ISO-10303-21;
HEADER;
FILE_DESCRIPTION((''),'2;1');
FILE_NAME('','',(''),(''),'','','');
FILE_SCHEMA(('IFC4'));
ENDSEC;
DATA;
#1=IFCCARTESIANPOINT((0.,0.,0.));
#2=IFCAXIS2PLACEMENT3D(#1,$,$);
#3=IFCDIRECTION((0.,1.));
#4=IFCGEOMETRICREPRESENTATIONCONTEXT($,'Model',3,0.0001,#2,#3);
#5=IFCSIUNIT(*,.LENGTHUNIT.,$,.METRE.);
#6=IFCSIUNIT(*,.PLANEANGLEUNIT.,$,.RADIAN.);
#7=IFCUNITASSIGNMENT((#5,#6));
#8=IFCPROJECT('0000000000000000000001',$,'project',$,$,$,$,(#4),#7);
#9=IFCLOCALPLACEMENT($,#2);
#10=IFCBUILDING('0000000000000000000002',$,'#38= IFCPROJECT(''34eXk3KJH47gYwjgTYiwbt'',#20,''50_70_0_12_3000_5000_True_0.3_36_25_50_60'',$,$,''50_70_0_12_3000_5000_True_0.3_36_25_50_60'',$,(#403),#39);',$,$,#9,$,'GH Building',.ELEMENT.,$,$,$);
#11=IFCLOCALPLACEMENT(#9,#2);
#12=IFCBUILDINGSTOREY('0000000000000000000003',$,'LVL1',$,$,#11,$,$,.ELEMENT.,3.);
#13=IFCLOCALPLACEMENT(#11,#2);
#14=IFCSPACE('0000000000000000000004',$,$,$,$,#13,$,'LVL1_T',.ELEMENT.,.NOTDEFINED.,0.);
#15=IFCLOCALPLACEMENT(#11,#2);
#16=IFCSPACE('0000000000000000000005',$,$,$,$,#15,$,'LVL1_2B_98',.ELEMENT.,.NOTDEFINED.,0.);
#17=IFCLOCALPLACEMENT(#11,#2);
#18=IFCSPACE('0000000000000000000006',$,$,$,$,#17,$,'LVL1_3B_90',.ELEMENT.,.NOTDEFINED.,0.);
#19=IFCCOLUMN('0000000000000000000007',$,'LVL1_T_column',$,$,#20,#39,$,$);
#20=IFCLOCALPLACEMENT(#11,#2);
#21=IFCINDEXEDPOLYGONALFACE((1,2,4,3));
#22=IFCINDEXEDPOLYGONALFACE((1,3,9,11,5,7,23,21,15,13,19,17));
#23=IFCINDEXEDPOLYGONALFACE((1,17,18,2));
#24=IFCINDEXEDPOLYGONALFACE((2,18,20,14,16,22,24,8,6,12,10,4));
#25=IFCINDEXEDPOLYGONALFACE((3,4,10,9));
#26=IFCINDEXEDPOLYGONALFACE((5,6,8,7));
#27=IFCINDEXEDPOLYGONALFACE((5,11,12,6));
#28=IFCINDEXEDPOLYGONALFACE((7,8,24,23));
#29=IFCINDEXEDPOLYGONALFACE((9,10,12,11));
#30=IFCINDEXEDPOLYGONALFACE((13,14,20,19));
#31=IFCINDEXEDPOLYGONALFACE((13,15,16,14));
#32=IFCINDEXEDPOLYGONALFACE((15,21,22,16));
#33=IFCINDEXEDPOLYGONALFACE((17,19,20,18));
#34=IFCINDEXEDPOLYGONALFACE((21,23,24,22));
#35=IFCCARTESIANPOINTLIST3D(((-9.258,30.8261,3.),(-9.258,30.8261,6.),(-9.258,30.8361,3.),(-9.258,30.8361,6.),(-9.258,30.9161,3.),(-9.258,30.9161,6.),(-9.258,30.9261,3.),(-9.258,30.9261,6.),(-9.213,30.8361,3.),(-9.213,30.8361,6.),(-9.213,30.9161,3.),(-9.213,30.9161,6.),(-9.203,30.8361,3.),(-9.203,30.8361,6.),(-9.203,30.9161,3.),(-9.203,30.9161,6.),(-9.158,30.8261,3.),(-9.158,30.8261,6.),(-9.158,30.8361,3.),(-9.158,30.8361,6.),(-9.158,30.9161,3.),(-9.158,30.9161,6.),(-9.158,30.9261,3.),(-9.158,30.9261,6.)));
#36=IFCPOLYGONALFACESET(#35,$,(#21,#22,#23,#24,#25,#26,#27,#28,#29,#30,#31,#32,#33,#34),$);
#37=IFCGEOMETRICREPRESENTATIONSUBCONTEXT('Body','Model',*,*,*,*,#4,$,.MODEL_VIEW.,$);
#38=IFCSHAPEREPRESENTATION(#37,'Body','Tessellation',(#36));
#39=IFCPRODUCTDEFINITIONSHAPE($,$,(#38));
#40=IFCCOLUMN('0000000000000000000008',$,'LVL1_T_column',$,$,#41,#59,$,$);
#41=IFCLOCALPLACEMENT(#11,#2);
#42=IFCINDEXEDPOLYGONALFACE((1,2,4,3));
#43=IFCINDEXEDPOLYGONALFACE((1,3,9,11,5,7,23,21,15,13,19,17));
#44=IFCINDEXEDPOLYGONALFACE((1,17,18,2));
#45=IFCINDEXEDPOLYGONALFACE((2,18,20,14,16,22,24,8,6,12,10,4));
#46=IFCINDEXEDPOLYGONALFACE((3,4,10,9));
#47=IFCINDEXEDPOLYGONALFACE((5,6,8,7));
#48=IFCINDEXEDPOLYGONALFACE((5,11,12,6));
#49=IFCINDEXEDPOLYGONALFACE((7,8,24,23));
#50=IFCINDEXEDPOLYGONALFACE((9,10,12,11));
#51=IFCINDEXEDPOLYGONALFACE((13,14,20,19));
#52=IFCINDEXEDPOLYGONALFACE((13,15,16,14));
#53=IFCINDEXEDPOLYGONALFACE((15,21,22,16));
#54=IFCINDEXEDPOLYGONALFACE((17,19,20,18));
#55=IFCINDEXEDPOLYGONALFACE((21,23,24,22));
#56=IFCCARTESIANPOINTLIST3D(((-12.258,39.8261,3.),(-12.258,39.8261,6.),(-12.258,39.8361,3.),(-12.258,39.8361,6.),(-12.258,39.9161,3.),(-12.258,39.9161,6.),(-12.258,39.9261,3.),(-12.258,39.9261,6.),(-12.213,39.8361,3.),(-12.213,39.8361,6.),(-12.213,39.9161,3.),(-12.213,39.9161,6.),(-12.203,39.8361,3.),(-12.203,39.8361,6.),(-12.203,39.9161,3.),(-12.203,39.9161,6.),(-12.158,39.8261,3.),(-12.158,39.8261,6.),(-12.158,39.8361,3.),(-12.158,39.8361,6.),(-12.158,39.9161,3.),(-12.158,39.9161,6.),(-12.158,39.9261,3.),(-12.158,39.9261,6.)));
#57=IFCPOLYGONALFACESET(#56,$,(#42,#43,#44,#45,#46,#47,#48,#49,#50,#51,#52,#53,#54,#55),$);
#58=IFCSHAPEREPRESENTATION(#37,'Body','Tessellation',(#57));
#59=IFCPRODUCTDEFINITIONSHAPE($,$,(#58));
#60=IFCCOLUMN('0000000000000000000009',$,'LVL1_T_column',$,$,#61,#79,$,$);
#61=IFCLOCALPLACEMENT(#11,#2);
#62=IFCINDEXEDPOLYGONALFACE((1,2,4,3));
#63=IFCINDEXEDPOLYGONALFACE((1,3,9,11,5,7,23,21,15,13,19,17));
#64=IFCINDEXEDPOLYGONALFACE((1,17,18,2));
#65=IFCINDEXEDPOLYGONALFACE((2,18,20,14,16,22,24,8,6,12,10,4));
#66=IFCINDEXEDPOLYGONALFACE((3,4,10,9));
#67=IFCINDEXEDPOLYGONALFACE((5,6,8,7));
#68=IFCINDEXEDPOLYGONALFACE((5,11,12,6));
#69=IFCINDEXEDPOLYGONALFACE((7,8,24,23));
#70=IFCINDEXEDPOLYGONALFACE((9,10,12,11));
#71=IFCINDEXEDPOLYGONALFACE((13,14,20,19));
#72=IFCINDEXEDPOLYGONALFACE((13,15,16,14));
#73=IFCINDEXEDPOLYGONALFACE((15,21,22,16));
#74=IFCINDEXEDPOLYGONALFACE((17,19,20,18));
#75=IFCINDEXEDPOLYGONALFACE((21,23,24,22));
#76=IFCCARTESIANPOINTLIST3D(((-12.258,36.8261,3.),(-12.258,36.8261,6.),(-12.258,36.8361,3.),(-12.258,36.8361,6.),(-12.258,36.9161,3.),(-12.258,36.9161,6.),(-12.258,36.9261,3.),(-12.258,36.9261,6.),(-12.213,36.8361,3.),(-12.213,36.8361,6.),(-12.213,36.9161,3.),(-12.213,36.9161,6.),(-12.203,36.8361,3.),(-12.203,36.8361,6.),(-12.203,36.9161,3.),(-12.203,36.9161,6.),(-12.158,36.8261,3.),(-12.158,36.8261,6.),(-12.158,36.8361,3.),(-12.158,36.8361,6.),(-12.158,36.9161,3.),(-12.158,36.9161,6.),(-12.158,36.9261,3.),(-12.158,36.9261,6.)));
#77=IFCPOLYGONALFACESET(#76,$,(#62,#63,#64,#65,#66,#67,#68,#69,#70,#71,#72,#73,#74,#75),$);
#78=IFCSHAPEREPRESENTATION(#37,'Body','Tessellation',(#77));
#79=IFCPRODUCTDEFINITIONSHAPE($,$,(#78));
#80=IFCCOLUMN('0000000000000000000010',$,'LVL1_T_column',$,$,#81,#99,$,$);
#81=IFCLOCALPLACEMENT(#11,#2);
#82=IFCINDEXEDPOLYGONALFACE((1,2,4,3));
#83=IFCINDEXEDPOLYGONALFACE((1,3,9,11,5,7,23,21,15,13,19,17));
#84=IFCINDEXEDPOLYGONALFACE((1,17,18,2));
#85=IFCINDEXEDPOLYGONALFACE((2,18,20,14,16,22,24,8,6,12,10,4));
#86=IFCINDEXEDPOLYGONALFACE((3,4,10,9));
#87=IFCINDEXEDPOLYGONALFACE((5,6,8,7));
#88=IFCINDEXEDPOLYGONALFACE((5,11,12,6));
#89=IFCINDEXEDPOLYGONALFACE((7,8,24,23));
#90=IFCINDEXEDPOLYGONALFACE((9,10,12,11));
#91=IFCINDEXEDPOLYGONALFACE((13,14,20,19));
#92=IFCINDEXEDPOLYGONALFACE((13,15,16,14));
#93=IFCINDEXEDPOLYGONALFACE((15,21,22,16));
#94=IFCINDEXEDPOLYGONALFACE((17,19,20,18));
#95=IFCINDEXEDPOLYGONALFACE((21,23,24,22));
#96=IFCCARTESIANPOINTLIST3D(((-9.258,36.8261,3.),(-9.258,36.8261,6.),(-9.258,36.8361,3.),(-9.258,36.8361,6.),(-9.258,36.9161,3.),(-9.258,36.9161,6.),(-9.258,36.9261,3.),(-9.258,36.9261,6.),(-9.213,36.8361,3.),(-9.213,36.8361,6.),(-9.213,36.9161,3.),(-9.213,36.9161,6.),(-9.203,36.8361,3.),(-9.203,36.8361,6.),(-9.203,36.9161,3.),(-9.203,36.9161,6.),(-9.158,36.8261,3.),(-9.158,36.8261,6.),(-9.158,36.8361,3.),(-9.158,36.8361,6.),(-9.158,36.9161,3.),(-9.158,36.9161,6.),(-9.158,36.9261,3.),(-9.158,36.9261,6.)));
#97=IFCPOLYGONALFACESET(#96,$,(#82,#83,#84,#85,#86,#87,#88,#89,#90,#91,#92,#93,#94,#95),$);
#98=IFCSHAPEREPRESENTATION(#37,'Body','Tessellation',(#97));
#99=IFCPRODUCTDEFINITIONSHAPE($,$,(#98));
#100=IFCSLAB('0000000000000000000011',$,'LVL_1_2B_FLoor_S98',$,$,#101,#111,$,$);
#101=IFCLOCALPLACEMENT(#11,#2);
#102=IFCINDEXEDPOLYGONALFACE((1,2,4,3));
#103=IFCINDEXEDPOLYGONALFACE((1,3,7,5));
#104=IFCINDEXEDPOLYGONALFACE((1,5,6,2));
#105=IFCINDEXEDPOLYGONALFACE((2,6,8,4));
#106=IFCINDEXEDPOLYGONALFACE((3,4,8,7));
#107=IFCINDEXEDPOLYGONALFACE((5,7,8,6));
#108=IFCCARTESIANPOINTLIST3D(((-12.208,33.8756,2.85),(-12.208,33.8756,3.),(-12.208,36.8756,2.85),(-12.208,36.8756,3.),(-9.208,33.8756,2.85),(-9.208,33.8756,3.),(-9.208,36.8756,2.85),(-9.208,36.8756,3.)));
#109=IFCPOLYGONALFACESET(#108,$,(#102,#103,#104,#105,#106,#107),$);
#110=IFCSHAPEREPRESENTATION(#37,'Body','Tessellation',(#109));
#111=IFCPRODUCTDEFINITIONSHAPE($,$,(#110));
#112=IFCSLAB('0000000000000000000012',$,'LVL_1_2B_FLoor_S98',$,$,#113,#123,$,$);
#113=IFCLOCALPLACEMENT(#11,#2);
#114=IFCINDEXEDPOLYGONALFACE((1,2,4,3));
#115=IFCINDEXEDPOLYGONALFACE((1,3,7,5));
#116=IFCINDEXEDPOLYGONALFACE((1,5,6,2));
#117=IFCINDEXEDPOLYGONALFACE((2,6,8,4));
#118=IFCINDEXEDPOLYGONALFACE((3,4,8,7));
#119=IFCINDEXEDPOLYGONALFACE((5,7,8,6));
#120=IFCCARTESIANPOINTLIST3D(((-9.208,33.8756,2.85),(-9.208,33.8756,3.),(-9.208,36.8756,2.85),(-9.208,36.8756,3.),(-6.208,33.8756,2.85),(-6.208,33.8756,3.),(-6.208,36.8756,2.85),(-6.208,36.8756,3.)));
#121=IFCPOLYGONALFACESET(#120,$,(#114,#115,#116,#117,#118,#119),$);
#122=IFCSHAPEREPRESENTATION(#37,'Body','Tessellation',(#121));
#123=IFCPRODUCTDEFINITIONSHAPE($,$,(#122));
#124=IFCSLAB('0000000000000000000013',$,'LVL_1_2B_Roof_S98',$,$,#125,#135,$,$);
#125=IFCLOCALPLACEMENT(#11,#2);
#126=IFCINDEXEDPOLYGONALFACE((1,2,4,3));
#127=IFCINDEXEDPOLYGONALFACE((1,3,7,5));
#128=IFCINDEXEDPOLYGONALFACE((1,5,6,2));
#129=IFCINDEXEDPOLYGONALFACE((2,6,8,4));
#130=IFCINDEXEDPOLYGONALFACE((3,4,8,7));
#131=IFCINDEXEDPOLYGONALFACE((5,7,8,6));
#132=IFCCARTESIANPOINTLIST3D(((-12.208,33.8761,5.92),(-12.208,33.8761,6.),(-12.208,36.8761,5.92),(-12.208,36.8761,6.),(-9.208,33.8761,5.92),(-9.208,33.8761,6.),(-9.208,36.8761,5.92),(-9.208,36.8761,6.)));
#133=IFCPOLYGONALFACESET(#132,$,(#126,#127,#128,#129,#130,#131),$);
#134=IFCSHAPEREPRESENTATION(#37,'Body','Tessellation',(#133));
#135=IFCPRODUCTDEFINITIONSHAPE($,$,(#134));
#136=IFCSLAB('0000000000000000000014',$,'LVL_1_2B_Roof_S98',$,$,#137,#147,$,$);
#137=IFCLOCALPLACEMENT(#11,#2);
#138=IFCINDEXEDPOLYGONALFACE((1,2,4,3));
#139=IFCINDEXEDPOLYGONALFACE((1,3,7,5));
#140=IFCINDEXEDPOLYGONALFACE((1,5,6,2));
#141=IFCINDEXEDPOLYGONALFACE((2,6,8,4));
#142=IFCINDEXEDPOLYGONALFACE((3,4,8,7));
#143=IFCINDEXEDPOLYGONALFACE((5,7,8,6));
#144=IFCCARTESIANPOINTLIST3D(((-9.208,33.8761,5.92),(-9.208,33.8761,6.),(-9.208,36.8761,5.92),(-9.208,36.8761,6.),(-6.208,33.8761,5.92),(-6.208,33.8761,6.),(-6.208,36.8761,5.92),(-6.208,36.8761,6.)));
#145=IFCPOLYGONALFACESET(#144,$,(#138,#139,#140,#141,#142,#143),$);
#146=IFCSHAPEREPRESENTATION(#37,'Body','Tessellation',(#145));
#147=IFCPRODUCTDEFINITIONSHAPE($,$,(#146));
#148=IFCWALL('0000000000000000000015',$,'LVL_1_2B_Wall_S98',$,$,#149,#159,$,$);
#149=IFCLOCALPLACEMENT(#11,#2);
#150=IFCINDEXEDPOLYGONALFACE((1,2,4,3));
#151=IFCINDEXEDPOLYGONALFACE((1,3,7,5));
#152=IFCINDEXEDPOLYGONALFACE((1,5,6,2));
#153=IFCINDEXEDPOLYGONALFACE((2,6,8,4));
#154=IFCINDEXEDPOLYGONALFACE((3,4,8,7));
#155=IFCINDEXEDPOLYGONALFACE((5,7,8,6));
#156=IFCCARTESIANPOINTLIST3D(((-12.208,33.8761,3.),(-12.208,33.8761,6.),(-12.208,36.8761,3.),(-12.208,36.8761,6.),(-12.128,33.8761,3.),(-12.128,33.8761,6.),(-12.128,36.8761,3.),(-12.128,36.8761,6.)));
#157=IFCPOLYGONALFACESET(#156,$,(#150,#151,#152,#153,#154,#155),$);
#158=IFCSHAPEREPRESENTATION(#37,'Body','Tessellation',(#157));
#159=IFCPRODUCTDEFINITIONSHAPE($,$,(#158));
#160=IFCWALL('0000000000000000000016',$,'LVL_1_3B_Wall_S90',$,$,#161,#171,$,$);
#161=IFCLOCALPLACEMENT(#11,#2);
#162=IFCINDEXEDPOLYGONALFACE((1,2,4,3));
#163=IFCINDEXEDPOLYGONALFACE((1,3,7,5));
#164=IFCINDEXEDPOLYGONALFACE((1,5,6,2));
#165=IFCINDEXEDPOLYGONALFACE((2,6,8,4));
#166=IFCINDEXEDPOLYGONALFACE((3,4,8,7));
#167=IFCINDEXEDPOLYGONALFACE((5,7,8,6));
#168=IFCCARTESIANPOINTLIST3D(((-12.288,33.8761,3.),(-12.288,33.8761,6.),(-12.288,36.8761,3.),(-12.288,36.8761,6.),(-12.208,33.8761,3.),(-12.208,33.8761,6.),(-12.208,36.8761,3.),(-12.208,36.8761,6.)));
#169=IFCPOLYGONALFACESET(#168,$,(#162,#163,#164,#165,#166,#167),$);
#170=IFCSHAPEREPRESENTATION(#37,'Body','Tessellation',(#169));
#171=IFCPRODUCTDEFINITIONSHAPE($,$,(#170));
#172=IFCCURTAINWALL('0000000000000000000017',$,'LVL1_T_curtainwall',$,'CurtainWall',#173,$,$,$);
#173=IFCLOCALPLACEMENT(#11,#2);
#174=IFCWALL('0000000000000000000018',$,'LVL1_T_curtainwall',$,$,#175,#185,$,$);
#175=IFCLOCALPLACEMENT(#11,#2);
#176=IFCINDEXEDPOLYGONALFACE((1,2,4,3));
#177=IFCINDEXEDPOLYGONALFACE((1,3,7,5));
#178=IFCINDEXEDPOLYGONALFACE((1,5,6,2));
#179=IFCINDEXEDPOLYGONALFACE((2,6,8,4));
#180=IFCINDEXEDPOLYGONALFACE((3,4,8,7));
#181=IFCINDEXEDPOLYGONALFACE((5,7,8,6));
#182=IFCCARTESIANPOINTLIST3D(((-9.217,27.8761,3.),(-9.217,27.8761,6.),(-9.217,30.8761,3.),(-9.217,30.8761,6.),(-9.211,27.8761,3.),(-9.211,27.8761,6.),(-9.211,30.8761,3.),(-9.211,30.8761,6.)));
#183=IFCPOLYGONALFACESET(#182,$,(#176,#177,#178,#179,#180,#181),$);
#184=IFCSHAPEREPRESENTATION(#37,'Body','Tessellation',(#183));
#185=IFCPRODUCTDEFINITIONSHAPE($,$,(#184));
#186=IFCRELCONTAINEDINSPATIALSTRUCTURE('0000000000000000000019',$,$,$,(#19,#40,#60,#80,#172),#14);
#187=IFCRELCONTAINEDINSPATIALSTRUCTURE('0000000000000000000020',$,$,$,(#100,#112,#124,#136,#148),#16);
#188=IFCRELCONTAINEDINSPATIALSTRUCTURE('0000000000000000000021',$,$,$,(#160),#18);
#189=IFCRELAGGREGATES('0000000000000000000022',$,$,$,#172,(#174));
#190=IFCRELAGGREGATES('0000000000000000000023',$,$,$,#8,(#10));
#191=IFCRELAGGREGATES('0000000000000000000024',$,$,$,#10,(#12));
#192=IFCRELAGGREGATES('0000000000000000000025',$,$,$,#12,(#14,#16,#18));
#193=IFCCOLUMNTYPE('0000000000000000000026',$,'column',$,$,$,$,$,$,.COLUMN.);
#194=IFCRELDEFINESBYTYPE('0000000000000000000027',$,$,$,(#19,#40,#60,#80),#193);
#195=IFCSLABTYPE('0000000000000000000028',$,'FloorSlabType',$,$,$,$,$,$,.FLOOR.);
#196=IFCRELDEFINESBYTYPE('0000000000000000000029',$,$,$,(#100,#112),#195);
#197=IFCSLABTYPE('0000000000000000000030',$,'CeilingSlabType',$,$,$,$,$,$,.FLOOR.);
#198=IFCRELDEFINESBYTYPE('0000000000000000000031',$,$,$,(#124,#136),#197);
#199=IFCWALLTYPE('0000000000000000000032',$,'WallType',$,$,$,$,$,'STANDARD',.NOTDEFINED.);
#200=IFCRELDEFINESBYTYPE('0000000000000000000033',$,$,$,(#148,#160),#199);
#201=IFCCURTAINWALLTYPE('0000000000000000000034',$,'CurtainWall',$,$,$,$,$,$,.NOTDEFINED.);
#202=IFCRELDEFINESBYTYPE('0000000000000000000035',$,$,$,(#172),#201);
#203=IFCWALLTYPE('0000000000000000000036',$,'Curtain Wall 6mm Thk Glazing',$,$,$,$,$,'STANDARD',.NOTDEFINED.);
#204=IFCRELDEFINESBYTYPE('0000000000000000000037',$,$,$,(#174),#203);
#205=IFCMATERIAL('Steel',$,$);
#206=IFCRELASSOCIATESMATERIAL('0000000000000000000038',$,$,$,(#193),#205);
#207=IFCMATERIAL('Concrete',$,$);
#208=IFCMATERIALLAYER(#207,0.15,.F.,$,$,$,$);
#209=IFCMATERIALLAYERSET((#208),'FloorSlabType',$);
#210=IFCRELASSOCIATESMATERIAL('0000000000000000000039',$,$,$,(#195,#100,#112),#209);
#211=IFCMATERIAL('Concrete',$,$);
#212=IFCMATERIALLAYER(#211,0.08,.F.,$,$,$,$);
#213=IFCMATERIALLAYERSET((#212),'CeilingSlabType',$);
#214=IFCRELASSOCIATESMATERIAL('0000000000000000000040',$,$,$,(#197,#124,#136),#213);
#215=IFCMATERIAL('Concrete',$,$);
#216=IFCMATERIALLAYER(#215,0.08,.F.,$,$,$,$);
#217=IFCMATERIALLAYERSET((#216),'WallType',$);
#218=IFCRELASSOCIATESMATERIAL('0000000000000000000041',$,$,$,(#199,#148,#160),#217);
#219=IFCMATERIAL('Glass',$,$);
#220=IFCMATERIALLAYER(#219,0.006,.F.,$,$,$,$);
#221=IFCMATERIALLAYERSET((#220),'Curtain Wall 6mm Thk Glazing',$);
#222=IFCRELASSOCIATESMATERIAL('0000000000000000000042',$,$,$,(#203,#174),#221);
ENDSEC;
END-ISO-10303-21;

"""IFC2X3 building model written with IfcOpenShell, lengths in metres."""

from ifc_helpers import new_model, si_unit, direction, frame, frame_2d, origin, origin_2d, place, context, subcontext, project, spatial, rectangle, i_section, extrude, material, layer, layer_set, layer_usage, type_object, element, aggregate, save


model = new_model("IFC2X3")

# Units and contexts
model_context = context("Model", 3, precision=0.0001, world=origin(), true_north=direction((0.0, 1.0)))
body_context = subcontext(model_context, "Body", "Model", "MODEL_VIEW")
ifc_project = project(units=[si_unit("LENGTHUNIT", "METRE"), si_unit("PLANEANGLEUNIT", "RADIAN")], contexts=[model_context])

# Building, storey, space
building_placement = place(None, origin())
building = spatial("IfcBuilding", under=ifc_project, at=building_placement, Name="#38= IFCPROJECT('34eXk3KJH47gYwjgTYiwbt',#20,'50_70_0_12_3000_5000_True_0.3_36_25_50_60',$,$,'50_70_0_12_3000_5000_True_0.3_36_25_50_60',$,(#403),#39);", LongName="GH Building", CompositionType="ELEMENT")
storey_placement = place(building_placement, origin())
storey = spatial("IfcBuildingStorey", under=building, at=storey_placement, Name="LVL1", CompositionType="ELEMENT", Elevation=3.0)
space_1_placement = place(storey_placement, origin())
space_1 = spatial("IfcSpace", under=storey, at=space_1_placement, LongName="LVL1_T", CompositionType="ELEMENT", InteriorOrExteriorSpace="NOTDEFINED", ElevationWithFlooring=0.0)

# Columns
ifc_material_1 = material(Name="Steel")
column_type = type_object("IfcColumnType", Name="column", PredefinedType="COLUMN", material=ifc_material_1)
for number, where, name in (
    (1, (-9.208, 30.8761, 3.0), "LVL1_T_column"),
    (2, (-12.208, 39.8761, 3.0), "LVL1_T_column"),
    (3, (-12.208, 36.8761, 3.0), "LVL1_T_column"),
    (4, (-9.208, 36.8761, 3.0), "LVL1_T_column"),
):
    element("IfcColumn", number, at=place(space_1_placement, frame(where)), inside=space_1, type_object=column_type, Name=name, context=body_context, shape_type="SweptSolid", body=[
        extrude(i_section(OverallWidth=0.1, OverallDepth=0.1, WebThickness=0.01, FlangeThickness=0.01, at=origin_2d()), origin(), (0.0, 0.0, 1.0), 3.0),
    ])

# Shared definitions
space_2_placement = place(storey_placement, origin())
space_2 = spatial("IfcSpace", under=storey, at=space_2_placement, LongName="LVL1_2B_98", CompositionType="ELEMENT", InteriorOrExteriorSpace="NOTDEFINED", ElevationWithFlooring=0.0)

# Slabs
ifc_material_2 = material(Name="Concrete")
ifc_layer_1 = layer(ifc_material_2, 0.15, ventilated=False)
ifc_layer_set_1 = layer_set([ifc_layer_1], Name="FloorSlabType")
ifc_layer_usage_1 = layer_usage(ifc_layer_set_1, "AXIS3", "NEGATIVE", -0.15)
slab_type_1 = type_object("IfcSlabType", Name="FloorSlabType", PredefinedType="FLOOR", material=ifc_layer_set_1)
slab_1_placement = place(space_2_placement, frame((-12.208, 33.8756, 2.85)))
element("IfcSlab", 5, at=slab_1_placement, inside=space_2, type_object=slab_type_1, material=ifc_layer_usage_1, Name="LVL_1_2B_FLoor_S98", context=body_context, shape_type="SweptSolid", body=[
    extrude(rectangle(XDim=3.0, YDim=3.0, at=frame_2d((1.5, 1.5))), origin(), (0.0, 0.0, 1.0), 0.15),
])
ifc_layer_usage_2 = layer_usage(ifc_layer_set_1, "AXIS3", "NEGATIVE", -0.15)
slab_2_placement = place(space_2_placement, frame((-9.208, 33.8756, 2.85)))
element("IfcSlab", 6, at=slab_2_placement, inside=space_2, type_object=slab_type_1, material=ifc_layer_usage_2, Name="LVL_1_2B_FLoor_S98", context=body_context, shape_type="SweptSolid", body=[
    extrude(rectangle(XDim=3.0, YDim=3.0, at=frame_2d((1.5, 1.5))), origin(), (0.0, 0.0, 1.0), 0.15),
])
ifc_material_3 = material(Name="Concrete")
ifc_layer_2 = layer(ifc_material_3, 0.08, ventilated=False)
ifc_layer_set_2 = layer_set([ifc_layer_2], Name="CeilingSlabType")
ifc_layer_usage_3 = layer_usage(ifc_layer_set_2, "AXIS3", "NEGATIVE", -0.08)
slab_type_2 = type_object("IfcSlabType", Name="CeilingSlabType", PredefinedType="FLOOR", material=ifc_layer_set_2)
slab_3_placement = place(space_2_placement, frame((-12.208, 33.8761, 5.92)))
element("IfcSlab", 7, at=slab_3_placement, inside=space_2, type_object=slab_type_2, material=ifc_layer_usage_3, Name="LVL_1_2B_Roof_S98", context=body_context, shape_type="SweptSolid", body=[
    extrude(rectangle(XDim=3.0, YDim=3.0, at=frame_2d((1.5, 1.5))), origin(), (0.0, 0.0, 1.0), 0.08),
])
ifc_layer_usage_4 = layer_usage(ifc_layer_set_2, "AXIS3", "NEGATIVE", -0.08)
slab_4_placement = place(space_2_placement, frame((-9.208, 33.8761, 5.92)))
element("IfcSlab", 8, at=slab_4_placement, inside=space_2, type_object=slab_type_2, material=ifc_layer_usage_4, Name="LVL_1_2B_Roof_S98", context=body_context, shape_type="SweptSolid", body=[
    extrude(rectangle(XDim=3.0, YDim=3.0, at=frame_2d((1.5, 1.5))), origin(), (0.0, 0.0, 1.0), 0.08),
])

# Shared definitions
ifc_material_4 = material(Name="Concrete")
ifc_layer_3 = layer(ifc_material_4, 0.08, ventilated=False)
ifc_layer_set_3 = layer_set([ifc_layer_3], Name="WallType")
wall_type_1 = type_object("IfcWallType", Name="WallType", ElementType="STANDARD", PredefinedType="NOTDEFINED", material=ifc_layer_set_3)

# Shared definitions
space_3_placement = place(storey_placement, origin())
space_3 = spatial("IfcSpace", under=storey, at=space_3_placement, LongName="LVL1_3B_90", CompositionType="ELEMENT", InteriorOrExteriorSpace="NOTDEFINED", ElevationWithFlooring=0.0)

# Walls
ifc_layer_usage_5 = layer_usage(ifc_layer_set_3, "AXIS2", "NEGATIVE", 0.0)
wall_1_placement = place(space_2_placement, frame((-12.208, 33.8761, 3.0), z_axis=(0.0, 0.0, 1.0), x_axis=(0.0, 1.0, 0.0)))
element("IfcWall", 9, at=wall_1_placement, inside=space_2, type_object=wall_type_1, material=ifc_layer_usage_5, Name="LVL_1_2B_Wall_S98", context=body_context, shape_type="SweptSolid", body=[
    extrude(rectangle(XDim=3.0, YDim=0.08, at=frame_2d((1.5, -0.04))), origin(), (0.0, 0.0, 1.0), 3.0),
])
ifc_layer_usage_6 = layer_usage(ifc_layer_set_3, "AXIS2", "NEGATIVE", 0.0)
wall_2_placement = place(space_3_placement, frame((-12.208, 36.8761, 3.0), z_axis=(0.0, 0.0, 1.0), x_axis=(0.0, -1.0, 0.0)))
element("IfcWall", 10, at=wall_2_placement, inside=space_3, type_object=wall_type_1, material=ifc_layer_usage_6, Name="LVL_1_3B_Wall_S90", context=body_context, shape_type="SweptSolid", body=[
    extrude(rectangle(XDim=3.0, YDim=0.08, at=frame_2d((1.5, -0.04))), origin(), (0.0, 0.0, 1.0), 3.0),
])

# Curtain wall, wall
curtain_wall_type = type_object("IfcCurtainWallType", Name="CurtainWall", PredefinedType="NOTDEFINED")
curtain_wall_placement = place(None, origin())
curtain_wall = element("IfcCurtainWall", 11, at=curtain_wall_placement, inside=space_1, type_object=curtain_wall_type, Name="LVL1_T_curtainwall", ObjectType="CurtainWall")
ifc_material_5 = material(Name="Glass")
ifc_layer_4 = layer(ifc_material_5, 0.006, ventilated=False)
ifc_layer_set_4 = layer_set([ifc_layer_4], Name="Curtain Wall 6mm Thk Glazing")
ifc_layer_usage_7 = layer_usage(ifc_layer_set_4, "AXIS2", "NEGATIVE", -0.003)
wall_type_2 = type_object("IfcWallType", Name="Curtain Wall 6mm Thk Glazing", ElementType="STANDARD", PredefinedType="NOTDEFINED", material=ifc_layer_set_4)
wall_3_placement = place(curtain_wall_placement, frame((-9.208, 30.8761, 3.0), z_axis=(0.0, 0.0, 1.0), x_axis=(0.0, -1.0, 0.0)))
wall_3 = element("IfcWall", 12, at=wall_3_placement, type_object=wall_type_2, material=ifc_layer_usage_7, Name="LVL1_T_curtainwall", context=body_context, shape_type="SweptSolid", body=[
    extrude(rectangle(XDim=3.0, YDim=0.006, at=frame_2d((1.5, -0.006))), origin(), (0.0, 0.0, 1.0), 3.0),
])
aggregate(curtain_wall, [wall_3])

save(model, "model.ifc")
